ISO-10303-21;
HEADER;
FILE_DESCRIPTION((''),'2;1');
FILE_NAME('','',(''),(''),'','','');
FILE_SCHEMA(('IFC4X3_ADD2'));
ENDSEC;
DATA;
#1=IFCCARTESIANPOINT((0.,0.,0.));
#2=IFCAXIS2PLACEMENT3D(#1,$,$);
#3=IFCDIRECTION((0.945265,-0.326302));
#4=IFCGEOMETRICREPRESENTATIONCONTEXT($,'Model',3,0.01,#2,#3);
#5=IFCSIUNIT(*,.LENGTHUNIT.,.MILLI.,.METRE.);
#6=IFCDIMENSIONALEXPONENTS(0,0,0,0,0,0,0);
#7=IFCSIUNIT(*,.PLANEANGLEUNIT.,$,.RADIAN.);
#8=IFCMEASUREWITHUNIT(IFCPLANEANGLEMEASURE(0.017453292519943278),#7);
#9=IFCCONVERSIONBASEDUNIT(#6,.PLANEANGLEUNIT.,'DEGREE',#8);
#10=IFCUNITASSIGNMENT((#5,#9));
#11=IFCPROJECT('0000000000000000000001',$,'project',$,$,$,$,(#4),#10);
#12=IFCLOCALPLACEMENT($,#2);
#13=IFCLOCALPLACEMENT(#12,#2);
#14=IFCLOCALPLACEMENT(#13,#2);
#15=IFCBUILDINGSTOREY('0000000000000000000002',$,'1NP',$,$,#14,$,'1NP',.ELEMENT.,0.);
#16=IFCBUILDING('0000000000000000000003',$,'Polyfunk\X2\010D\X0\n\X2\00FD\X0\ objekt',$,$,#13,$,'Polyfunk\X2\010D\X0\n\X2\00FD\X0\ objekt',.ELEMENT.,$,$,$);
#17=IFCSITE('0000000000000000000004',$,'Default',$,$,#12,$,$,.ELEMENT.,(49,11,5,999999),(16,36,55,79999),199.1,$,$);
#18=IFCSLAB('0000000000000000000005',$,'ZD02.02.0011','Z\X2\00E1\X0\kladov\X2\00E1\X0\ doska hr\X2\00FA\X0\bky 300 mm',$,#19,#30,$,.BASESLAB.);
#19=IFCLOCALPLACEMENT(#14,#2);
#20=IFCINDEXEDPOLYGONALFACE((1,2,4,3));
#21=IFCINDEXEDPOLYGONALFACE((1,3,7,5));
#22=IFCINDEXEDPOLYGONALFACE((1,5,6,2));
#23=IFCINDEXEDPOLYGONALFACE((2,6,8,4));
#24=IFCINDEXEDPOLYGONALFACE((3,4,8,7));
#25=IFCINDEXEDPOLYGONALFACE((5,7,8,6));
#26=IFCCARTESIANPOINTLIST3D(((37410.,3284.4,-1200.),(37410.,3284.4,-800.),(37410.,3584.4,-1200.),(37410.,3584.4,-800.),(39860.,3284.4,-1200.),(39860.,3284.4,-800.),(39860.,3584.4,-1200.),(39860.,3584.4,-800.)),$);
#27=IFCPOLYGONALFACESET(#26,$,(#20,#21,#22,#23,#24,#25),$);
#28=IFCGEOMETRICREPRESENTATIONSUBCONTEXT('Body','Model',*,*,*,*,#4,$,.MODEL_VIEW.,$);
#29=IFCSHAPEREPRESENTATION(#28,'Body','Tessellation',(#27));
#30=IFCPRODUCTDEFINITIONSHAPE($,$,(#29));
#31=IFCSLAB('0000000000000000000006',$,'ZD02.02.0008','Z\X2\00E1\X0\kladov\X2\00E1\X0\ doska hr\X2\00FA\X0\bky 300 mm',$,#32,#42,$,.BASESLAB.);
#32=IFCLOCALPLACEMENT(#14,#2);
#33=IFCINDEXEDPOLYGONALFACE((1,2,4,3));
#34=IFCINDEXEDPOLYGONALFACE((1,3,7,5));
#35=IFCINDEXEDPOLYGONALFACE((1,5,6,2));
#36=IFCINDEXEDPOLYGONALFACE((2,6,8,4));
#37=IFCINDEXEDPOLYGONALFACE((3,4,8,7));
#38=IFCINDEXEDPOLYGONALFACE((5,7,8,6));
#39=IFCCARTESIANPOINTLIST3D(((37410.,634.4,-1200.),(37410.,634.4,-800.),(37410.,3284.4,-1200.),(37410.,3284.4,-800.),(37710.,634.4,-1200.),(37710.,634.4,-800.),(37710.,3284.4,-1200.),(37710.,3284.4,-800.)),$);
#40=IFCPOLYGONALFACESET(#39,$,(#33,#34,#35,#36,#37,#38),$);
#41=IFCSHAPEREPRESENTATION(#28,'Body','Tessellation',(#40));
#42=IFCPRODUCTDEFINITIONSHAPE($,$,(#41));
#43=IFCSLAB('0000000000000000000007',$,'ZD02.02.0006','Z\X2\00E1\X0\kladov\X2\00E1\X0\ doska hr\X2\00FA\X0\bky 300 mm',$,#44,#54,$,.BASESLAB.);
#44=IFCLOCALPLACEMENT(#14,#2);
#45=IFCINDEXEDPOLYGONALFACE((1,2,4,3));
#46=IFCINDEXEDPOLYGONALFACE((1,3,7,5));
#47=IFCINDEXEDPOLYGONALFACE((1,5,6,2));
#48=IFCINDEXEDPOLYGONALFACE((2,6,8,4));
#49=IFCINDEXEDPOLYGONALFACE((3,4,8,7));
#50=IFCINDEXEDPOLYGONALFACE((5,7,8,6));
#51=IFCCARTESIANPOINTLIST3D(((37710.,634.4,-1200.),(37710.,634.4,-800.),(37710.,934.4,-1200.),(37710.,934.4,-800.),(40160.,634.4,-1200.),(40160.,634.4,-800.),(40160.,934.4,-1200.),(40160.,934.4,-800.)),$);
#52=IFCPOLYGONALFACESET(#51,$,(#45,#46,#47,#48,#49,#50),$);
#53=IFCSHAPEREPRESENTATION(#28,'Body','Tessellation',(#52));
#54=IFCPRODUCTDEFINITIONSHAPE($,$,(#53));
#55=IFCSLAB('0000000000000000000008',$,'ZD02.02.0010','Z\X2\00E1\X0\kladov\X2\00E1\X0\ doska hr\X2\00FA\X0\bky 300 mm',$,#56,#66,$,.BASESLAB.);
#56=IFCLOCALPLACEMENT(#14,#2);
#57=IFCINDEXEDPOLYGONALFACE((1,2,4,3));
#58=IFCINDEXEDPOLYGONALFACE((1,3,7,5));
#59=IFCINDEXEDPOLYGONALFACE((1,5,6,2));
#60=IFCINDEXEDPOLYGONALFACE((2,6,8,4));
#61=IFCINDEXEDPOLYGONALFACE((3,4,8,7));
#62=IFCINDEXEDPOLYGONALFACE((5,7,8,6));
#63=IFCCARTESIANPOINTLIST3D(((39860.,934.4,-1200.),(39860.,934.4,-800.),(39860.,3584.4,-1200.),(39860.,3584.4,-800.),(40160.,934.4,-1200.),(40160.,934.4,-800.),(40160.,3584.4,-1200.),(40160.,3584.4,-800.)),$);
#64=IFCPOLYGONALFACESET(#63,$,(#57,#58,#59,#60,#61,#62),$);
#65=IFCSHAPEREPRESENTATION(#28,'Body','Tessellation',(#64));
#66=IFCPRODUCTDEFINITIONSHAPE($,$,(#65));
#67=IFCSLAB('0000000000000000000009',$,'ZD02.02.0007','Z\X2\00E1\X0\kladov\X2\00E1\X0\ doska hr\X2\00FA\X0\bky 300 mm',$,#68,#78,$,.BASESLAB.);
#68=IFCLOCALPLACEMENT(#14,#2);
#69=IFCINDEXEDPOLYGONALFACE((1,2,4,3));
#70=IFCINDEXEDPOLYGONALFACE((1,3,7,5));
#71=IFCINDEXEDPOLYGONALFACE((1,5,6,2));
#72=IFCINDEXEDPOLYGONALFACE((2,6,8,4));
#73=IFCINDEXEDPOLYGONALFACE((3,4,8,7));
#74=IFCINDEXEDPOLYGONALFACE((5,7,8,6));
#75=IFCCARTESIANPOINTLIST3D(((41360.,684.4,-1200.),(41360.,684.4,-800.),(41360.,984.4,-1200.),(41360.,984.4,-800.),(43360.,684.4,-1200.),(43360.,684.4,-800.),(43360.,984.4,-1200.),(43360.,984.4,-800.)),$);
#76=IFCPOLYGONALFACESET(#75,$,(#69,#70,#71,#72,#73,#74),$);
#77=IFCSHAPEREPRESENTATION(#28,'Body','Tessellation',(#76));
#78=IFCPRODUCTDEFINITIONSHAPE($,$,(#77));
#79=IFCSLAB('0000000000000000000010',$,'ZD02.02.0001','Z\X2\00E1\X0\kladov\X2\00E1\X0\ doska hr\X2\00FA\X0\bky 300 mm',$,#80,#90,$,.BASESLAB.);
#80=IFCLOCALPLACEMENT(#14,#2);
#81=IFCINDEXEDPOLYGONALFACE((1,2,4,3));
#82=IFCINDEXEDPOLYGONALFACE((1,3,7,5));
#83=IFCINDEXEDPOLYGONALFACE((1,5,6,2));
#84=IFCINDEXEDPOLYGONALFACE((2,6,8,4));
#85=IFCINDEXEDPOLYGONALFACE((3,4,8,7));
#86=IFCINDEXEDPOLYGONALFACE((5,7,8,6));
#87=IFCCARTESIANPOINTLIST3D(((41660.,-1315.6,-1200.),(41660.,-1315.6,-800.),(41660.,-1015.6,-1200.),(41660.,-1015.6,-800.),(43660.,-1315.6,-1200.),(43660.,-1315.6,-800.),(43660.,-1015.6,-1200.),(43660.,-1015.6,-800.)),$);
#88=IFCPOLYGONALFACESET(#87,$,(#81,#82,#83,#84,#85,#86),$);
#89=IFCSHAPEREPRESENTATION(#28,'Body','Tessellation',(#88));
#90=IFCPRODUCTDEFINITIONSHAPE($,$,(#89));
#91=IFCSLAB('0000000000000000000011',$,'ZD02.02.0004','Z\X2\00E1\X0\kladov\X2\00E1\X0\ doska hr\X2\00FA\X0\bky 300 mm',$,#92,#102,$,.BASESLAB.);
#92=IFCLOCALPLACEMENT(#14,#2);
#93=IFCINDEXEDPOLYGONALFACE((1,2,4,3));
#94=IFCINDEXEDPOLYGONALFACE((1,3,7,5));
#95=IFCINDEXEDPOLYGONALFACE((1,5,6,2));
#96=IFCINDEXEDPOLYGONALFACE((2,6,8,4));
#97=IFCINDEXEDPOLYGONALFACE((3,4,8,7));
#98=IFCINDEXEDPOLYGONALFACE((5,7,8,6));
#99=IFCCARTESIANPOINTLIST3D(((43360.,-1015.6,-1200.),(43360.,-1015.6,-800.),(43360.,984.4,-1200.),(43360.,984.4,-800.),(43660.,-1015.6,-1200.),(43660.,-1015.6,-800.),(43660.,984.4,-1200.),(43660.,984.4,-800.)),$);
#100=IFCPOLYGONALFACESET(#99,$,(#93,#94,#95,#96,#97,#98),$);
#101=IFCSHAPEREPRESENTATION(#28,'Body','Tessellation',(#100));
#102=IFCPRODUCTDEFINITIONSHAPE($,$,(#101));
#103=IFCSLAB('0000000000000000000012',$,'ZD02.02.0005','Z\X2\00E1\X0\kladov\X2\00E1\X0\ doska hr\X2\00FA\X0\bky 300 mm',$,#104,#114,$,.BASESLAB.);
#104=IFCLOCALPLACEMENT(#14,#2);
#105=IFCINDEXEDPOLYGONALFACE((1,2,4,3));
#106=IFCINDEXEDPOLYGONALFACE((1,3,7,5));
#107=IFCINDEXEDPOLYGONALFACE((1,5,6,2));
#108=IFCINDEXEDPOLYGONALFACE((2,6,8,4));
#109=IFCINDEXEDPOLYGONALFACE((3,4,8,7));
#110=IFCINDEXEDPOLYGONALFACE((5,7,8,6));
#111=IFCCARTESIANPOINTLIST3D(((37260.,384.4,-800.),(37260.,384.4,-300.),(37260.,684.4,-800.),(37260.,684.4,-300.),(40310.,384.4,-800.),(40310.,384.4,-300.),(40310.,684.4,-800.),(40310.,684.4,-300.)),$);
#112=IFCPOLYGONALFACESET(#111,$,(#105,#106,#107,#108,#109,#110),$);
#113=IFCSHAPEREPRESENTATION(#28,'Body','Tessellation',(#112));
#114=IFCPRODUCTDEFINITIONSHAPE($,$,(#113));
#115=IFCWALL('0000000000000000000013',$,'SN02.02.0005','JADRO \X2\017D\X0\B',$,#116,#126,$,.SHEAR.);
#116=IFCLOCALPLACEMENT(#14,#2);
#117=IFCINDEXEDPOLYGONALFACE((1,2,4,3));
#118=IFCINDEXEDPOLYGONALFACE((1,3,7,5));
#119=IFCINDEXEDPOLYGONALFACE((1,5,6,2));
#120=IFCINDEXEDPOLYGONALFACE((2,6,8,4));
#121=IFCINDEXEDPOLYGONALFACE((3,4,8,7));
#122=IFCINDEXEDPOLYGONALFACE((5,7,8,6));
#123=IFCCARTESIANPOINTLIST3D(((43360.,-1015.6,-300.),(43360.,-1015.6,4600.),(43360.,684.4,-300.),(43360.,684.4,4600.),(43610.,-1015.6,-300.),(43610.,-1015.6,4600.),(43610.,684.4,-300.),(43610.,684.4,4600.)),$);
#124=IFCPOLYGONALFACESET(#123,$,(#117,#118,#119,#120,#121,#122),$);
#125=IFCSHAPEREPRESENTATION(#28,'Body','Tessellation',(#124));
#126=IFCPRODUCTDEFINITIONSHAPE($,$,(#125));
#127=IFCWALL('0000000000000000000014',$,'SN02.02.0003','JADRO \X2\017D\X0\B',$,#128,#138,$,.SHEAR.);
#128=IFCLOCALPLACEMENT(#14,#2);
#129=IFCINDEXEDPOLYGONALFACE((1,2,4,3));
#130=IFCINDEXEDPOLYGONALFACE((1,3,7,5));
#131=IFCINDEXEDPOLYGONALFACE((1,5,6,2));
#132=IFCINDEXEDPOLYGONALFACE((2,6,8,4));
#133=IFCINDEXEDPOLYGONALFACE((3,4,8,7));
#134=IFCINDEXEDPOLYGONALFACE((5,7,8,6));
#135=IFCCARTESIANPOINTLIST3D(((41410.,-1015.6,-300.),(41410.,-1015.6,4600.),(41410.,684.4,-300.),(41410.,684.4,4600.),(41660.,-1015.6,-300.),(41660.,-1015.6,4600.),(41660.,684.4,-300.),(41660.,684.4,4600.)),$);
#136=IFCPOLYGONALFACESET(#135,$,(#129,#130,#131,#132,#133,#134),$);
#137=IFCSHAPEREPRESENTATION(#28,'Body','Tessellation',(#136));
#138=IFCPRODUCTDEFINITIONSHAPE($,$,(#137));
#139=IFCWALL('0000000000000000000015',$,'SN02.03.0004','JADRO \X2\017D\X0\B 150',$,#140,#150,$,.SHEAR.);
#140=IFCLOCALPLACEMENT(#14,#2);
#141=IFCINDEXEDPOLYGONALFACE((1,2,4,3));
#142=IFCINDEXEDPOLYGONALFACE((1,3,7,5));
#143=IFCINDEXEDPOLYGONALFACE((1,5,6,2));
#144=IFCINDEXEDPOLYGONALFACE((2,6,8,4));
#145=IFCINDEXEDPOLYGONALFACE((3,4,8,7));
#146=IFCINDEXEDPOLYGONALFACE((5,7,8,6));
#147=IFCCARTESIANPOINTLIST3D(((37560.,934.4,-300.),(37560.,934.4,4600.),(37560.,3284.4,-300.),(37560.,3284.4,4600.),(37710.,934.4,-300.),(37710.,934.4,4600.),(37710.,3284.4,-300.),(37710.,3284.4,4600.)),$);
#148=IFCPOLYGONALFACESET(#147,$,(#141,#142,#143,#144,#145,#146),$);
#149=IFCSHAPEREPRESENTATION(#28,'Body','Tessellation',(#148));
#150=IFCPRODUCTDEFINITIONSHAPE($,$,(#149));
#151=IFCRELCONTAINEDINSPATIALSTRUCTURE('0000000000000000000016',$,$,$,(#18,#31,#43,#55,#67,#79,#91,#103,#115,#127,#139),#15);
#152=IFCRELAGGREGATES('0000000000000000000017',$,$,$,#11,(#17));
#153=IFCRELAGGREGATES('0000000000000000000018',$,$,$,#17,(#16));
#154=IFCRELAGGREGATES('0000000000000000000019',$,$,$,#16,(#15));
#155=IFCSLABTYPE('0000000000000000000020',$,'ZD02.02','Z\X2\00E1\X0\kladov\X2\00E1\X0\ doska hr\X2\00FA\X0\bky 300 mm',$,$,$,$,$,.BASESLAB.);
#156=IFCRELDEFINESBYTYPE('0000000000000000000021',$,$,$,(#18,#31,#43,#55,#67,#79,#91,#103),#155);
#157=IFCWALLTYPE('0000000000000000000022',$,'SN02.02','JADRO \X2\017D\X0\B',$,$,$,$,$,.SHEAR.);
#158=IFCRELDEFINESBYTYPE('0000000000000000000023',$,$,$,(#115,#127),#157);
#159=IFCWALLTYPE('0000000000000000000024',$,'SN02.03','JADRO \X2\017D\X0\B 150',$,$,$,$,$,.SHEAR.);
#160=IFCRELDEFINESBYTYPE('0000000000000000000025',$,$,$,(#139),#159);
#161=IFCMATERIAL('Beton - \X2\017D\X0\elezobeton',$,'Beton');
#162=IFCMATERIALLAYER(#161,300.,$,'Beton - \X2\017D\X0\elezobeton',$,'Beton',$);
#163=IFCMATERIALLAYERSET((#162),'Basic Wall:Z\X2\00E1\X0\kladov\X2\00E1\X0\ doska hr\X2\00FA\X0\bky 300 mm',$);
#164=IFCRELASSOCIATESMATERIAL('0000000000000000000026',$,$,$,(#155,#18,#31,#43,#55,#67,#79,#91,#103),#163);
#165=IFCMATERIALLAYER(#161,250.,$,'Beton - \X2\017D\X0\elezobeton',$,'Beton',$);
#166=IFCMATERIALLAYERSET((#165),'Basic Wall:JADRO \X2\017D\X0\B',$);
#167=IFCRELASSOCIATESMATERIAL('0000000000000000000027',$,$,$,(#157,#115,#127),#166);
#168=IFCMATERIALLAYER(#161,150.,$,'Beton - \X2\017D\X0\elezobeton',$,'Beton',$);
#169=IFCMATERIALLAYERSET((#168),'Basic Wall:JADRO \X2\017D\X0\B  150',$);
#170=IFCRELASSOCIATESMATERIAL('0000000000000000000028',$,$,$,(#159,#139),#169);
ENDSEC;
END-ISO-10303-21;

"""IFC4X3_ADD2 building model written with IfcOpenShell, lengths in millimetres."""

from ifc_helpers import new_model, entity, si_unit, converted_unit, direction, frame, frame_2d, origin, place, context, subcontext, project, spatial, polyline, rectangle, extrude, clip, bounded_halfspace, material, layer, layer_set, type_object, element, save


model = new_model("IFC4X3_ADD2")

# Units and contexts
model_context = context("Model", 3, precision=0.01, world=origin(), true_north=direction((0.945265, -0.326302)))
body_context = subcontext(model_context, "Body", "Model", "MODEL_VIEW")
ifc_project = project(units=[si_unit("LENGTHUNIT", "METRE", prefix="MILLI"), converted_unit("PLANEANGLEUNIT", "DEGREE", entity("IfcPlaneAngleMeasure", 0.017453292519943278), si_unit("PLANEANGLEUNIT", "RADIAN"), dimensions=[0, 0, 0, 0, 0, 0, 0])], contexts=[model_context])

# Site, building, storey
site_placement = place(None, origin())
site = spatial("IfcSite", under=ifc_project, at=site_placement, Name="Default", CompositionType="ELEMENT", RefLatitude=(49, 11, 5, 999999), RefLongitude=(16, 36, 55, 79999), RefElevation=199.1)
building_placement = place(site_placement, origin())
building = spatial("IfcBuilding", under=site, at=building_placement, Name="Polyfunkčný objekt", LongName="Polyfunkčný objekt", CompositionType="ELEMENT")
storey_placement = place(building_placement, origin())
storey = spatial("IfcBuildingStorey", under=building, at=storey_placement, Name="1NP", LongName="1NP", CompositionType="ELEMENT", Elevation=0.0)

# Slabs
ifc_material_1 = material(Name="Beton - Železobeton", Category="Beton")
ifc_layer_1 = layer(ifc_material_1, 300.0, Name="Beton - Železobeton", Category="Beton")
ifc_layer_set_1 = layer_set([ifc_layer_1], Name="Basic Wall:Základová doska hrúbky 300 mm")
slab_type = type_object("IfcSlabType", Name="ZD02.02", Description="Základová doska hrúbky 300 mm", PredefinedType="BASESLAB", material=ifc_layer_set_1)
slab_1_placement = place(storey_placement, frame((37410.0, 3434.4, -1200.0)))
element("IfcSlab", 1, at=slab_1_placement, inside=storey, type_object=slab_type, material=ifc_layer_set_1, Name="ZD02.02.0011", Description="Základová doska hrúbky 300 mm", PredefinedType="BASESLAB", context=body_context, shape_type="SweptSolid", body=[
    extrude(rectangle(XDim=2450.0, YDim=300.0, at=frame_2d((1225.0, 0.0), x_axis=(-1.0, 0.0))), origin(), (0.0, 0.0, 1.0), 400.0),
])
slab_2_placement = place(storey_placement, frame((37560.0, 634.4, -1200.0), z_axis=(0.0, 0.0, 1.0), x_axis=(0.0, 1.0, 0.0)))
element("IfcSlab", 2, at=slab_2_placement, inside=storey, type_object=slab_type, material=ifc_layer_set_1, Name="ZD02.02.0008", Description="Základová doska hrúbky 300 mm", PredefinedType="BASESLAB", context=body_context, shape_type="SweptSolid", body=[
    extrude(rectangle(XDim=2650.0, YDim=300.0, at=frame_2d((1325.0, 0.0), x_axis=(-1.0, 0.0))), origin(), (0.0, 0.0, 1.0), 400.0),
])
slab_3_placement = place(storey_placement, frame((40160.0, 784.4, -1200.0), z_axis=(0.0, 0.0, 1.0), x_axis=(-1.0, 0.0, 0.0)))
element("IfcSlab", 3, at=slab_3_placement, inside=storey, type_object=slab_type, material=ifc_layer_set_1, Name="ZD02.02.0006", Description="Základová doska hrúbky 300 mm", PredefinedType="BASESLAB", context=body_context, shape_type="SweptSolid", body=[
    extrude(rectangle(XDim=2450.0, YDim=300.0, at=frame_2d((1225.0, 0.0), x_axis=(-1.0, 0.0))), origin(), (0.0, 0.0, 1.0), 400.0),
])
slab_4_placement = place(storey_placement, frame((40010.0, 3584.4, -1200.0), z_axis=(0.0, 0.0, 1.0), x_axis=(0.0, -1.0, 0.0)))
element("IfcSlab", 4, at=slab_4_placement, inside=storey, type_object=slab_type, material=ifc_layer_set_1, Name="ZD02.02.0010", Description="Základová doska hrúbky 300 mm", PredefinedType="BASESLAB", context=body_context, shape_type="SweptSolid", body=[
    extrude(rectangle(XDim=2650.0, YDim=300.0, at=frame_2d((1325.0, 0.0), x_axis=(-1.0, 0.0))), origin(), (0.0, 0.0, 1.0), 400.0),
])
slab_5_placement = place(storey_placement, frame((41360.0, 834.4, -1200.0)))
element("IfcSlab", 5, at=slab_5_placement, inside=storey, type_object=slab_type, material=ifc_layer_set_1, Name="ZD02.02.0007", Description="Základová doska hrúbky 300 mm", PredefinedType="BASESLAB", context=body_context, shape_type="SweptSolid", body=[
    extrude(rectangle(XDim=2000.0, YDim=300.0, at=frame_2d((1000.0, 0.0), x_axis=(-1.0, 0.0))), origin(), (0.0, 0.0, 1.0), 400.0),
])
slab_6_placement = place(storey_placement, frame((43660.0, -1165.6, -1200.0), z_axis=(0.0, 0.0, 1.0), x_axis=(-1.0, 0.0, 0.0)))
element("IfcSlab", 6, at=slab_6_placement, inside=storey, type_object=slab_type, material=ifc_layer_set_1, Name="ZD02.02.0001", Description="Základová doska hrúbky 300 mm", PredefinedType="BASESLAB", context=body_context, shape_type="SweptSolid", body=[
    extrude(rectangle(XDim=2000.0, YDim=300.0, at=frame_2d((1000.0, 0.0), x_axis=(-1.0, 0.0))), origin(), (0.0, 0.0, 1.0), 400.0),
])
slab_7_placement = place(storey_placement, frame((43510.0, 984.4, -1200.0), z_axis=(0.0, 0.0, 1.0), x_axis=(0.0, -1.0, 0.0)))
element("IfcSlab", 7, at=slab_7_placement, inside=storey, type_object=slab_type, material=ifc_layer_set_1, Name="ZD02.02.0004", Description="Základová doska hrúbky 300 mm", PredefinedType="BASESLAB", context=body_context, shape_type="SweptSolid", body=[
    extrude(rectangle(XDim=2000.0, YDim=300.0, at=frame_2d((1000.0, 0.0), x_axis=(-1.0, 0.0))), origin(), (0.0, 0.0, 1.0), 400.0),
])
slab_8_placement = place(storey_placement, frame((40310.0, 534.4, -800.0), z_axis=(0.0, 0.0, 1.0), x_axis=(-1.0, 0.0, 0.0)))
element("IfcSlab", 8, at=slab_8_placement, inside=storey, type_object=slab_type, material=ifc_layer_set_1, Name="ZD02.02.0005", Description="Základová doska hrúbky 300 mm", PredefinedType="BASESLAB", context=body_context, shape_type="SweptSolid", body=[
    extrude(rectangle(XDim=3050.0, YDim=300.0, at=frame_2d((1525.0, 0.0), x_axis=(-1.0, 0.0))), origin(), (0.0, 0.0, 1.0), 500.0),
])

# Walls
ifc_layer_2 = layer(ifc_material_1, 250.0, Name="Beton - Železobeton", Category="Beton")
ifc_layer_set_2 = layer_set([ifc_layer_2], Name="Basic Wall:JADRO ŽB")
wall_type_1 = type_object("IfcWallType", Name="SN02.02", Description="JADRO ŽB", PredefinedType="SHEAR", material=ifc_layer_set_2)
wall_1_placement = place(storey_placement, frame((43485.0, 684.4, -300.0), z_axis=(0.0, 0.0, 1.0), x_axis=(0.0, -1.0, 0.0)))
element("IfcWall", 9, at=wall_1_placement, inside=storey, type_object=wall_type_1, material=ifc_layer_set_2, Name="SN02.02.0005", Description="JADRO ŽB", PredefinedType="SHEAR", context=body_context, shape_type="Clipping", body=[
    clip(clip(extrude(rectangle(XDim=1700.0, YDim=250.0, at=frame_2d((850.0, 0.0), x_axis=(-1.0, 0.0))), origin(), (0.0, 0.0, 1.0), 4900.0), bounded_halfspace(frame((0.0, -125.0, 4900.0), z_axis=(0.0, 0.0, -1.0), x_axis=(0.0, 1.0, 0.0)), True, frame((0.0, -125.0, 4900.0)), polyline([(0.0, 0.0), (1700.0, 0.0), (1700.0, 250.0), (0.0, 250.0), (0.0, 0.0)]))), bounded_halfspace(frame((1700.0, -125.0, 0.0), z_axis=(0.0, 0.0, 1.0), x_axis=(-1.0, 0.0, 0.0)), True, frame((1700.0, -125.0, 0.0)), polyline([(0.0, 0.0), (0.0, 250.0), (-1700.0, 250.0), (-1700.0, 0.0), (0.0, 0.0)]))),
])
wall_2_placement = place(storey_placement, frame((41535.0, 684.4, -300.0), z_axis=(0.0, 0.0, 1.0), x_axis=(0.0, -1.0, 0.0)))
element("IfcWall", 10, at=wall_2_placement, inside=storey, type_object=wall_type_1, material=ifc_layer_set_2, Name="SN02.02.0003", Description="JADRO ŽB", PredefinedType="SHEAR", context=body_context, shape_type="Clipping", body=[
    clip(clip(extrude(rectangle(XDim=1700.0, YDim=250.0, at=frame_2d((850.0, 0.0), x_axis=(-1.0, 0.0))), origin(), (0.0, 0.0, 1.0), 4900.0), bounded_halfspace(frame((0.0, -125.0, 4900.0), z_axis=(0.0, 0.0, -1.0), x_axis=(0.0, 1.0, 0.0)), True, frame((0.0, -125.0, 4900.0)), polyline([(0.0, 0.0), (1700.0, 0.0), (1700.0, 250.0), (0.0, 250.0), (0.0, 0.0)]))), bounded_halfspace(frame((1700.0, -125.0, 0.0), z_axis=(0.0, 0.0, 1.0), x_axis=(-1.0, 0.0, 0.0)), True, frame((1700.0, -125.0, 0.0)), polyline([(0.0, 0.0), (0.0, 250.0), (-1700.0, 250.0), (-1700.0, 0.0), (0.0, 0.0)]))),
])
ifc_layer_3 = layer(ifc_material_1, 150.0, Name="Beton - Železobeton", Category="Beton")
ifc_layer_set_3 = layer_set([ifc_layer_3], Name="Basic Wall:JADRO ŽB  150")
wall_type_2 = type_object("IfcWallType", Name="SN02.03", Description="JADRO ŽB 150", PredefinedType="SHEAR", material=ifc_layer_set_3)
wall_3_placement = place(storey_placement, frame((37635.0, 3284.4, -300.0), z_axis=(0.0, 0.0, 1.0), x_axis=(0.0, -1.0, 0.0)))
element("IfcWall", 11, at=wall_3_placement, inside=storey, type_object=wall_type_2, material=ifc_layer_set_3, Name="SN02.03.0004", Description="JADRO ŽB 150", PredefinedType="SHEAR", context=body_context, shape_type="SweptSolid", body=[
    extrude(rectangle(XDim=2350.0, YDim=150.0, at=frame_2d((1175.0, 0.0), x_axis=(-1.0, 0.0))), origin(), (0.0, 0.0, 1.0), 4900.0),
])

save(model, "model.ifc")
